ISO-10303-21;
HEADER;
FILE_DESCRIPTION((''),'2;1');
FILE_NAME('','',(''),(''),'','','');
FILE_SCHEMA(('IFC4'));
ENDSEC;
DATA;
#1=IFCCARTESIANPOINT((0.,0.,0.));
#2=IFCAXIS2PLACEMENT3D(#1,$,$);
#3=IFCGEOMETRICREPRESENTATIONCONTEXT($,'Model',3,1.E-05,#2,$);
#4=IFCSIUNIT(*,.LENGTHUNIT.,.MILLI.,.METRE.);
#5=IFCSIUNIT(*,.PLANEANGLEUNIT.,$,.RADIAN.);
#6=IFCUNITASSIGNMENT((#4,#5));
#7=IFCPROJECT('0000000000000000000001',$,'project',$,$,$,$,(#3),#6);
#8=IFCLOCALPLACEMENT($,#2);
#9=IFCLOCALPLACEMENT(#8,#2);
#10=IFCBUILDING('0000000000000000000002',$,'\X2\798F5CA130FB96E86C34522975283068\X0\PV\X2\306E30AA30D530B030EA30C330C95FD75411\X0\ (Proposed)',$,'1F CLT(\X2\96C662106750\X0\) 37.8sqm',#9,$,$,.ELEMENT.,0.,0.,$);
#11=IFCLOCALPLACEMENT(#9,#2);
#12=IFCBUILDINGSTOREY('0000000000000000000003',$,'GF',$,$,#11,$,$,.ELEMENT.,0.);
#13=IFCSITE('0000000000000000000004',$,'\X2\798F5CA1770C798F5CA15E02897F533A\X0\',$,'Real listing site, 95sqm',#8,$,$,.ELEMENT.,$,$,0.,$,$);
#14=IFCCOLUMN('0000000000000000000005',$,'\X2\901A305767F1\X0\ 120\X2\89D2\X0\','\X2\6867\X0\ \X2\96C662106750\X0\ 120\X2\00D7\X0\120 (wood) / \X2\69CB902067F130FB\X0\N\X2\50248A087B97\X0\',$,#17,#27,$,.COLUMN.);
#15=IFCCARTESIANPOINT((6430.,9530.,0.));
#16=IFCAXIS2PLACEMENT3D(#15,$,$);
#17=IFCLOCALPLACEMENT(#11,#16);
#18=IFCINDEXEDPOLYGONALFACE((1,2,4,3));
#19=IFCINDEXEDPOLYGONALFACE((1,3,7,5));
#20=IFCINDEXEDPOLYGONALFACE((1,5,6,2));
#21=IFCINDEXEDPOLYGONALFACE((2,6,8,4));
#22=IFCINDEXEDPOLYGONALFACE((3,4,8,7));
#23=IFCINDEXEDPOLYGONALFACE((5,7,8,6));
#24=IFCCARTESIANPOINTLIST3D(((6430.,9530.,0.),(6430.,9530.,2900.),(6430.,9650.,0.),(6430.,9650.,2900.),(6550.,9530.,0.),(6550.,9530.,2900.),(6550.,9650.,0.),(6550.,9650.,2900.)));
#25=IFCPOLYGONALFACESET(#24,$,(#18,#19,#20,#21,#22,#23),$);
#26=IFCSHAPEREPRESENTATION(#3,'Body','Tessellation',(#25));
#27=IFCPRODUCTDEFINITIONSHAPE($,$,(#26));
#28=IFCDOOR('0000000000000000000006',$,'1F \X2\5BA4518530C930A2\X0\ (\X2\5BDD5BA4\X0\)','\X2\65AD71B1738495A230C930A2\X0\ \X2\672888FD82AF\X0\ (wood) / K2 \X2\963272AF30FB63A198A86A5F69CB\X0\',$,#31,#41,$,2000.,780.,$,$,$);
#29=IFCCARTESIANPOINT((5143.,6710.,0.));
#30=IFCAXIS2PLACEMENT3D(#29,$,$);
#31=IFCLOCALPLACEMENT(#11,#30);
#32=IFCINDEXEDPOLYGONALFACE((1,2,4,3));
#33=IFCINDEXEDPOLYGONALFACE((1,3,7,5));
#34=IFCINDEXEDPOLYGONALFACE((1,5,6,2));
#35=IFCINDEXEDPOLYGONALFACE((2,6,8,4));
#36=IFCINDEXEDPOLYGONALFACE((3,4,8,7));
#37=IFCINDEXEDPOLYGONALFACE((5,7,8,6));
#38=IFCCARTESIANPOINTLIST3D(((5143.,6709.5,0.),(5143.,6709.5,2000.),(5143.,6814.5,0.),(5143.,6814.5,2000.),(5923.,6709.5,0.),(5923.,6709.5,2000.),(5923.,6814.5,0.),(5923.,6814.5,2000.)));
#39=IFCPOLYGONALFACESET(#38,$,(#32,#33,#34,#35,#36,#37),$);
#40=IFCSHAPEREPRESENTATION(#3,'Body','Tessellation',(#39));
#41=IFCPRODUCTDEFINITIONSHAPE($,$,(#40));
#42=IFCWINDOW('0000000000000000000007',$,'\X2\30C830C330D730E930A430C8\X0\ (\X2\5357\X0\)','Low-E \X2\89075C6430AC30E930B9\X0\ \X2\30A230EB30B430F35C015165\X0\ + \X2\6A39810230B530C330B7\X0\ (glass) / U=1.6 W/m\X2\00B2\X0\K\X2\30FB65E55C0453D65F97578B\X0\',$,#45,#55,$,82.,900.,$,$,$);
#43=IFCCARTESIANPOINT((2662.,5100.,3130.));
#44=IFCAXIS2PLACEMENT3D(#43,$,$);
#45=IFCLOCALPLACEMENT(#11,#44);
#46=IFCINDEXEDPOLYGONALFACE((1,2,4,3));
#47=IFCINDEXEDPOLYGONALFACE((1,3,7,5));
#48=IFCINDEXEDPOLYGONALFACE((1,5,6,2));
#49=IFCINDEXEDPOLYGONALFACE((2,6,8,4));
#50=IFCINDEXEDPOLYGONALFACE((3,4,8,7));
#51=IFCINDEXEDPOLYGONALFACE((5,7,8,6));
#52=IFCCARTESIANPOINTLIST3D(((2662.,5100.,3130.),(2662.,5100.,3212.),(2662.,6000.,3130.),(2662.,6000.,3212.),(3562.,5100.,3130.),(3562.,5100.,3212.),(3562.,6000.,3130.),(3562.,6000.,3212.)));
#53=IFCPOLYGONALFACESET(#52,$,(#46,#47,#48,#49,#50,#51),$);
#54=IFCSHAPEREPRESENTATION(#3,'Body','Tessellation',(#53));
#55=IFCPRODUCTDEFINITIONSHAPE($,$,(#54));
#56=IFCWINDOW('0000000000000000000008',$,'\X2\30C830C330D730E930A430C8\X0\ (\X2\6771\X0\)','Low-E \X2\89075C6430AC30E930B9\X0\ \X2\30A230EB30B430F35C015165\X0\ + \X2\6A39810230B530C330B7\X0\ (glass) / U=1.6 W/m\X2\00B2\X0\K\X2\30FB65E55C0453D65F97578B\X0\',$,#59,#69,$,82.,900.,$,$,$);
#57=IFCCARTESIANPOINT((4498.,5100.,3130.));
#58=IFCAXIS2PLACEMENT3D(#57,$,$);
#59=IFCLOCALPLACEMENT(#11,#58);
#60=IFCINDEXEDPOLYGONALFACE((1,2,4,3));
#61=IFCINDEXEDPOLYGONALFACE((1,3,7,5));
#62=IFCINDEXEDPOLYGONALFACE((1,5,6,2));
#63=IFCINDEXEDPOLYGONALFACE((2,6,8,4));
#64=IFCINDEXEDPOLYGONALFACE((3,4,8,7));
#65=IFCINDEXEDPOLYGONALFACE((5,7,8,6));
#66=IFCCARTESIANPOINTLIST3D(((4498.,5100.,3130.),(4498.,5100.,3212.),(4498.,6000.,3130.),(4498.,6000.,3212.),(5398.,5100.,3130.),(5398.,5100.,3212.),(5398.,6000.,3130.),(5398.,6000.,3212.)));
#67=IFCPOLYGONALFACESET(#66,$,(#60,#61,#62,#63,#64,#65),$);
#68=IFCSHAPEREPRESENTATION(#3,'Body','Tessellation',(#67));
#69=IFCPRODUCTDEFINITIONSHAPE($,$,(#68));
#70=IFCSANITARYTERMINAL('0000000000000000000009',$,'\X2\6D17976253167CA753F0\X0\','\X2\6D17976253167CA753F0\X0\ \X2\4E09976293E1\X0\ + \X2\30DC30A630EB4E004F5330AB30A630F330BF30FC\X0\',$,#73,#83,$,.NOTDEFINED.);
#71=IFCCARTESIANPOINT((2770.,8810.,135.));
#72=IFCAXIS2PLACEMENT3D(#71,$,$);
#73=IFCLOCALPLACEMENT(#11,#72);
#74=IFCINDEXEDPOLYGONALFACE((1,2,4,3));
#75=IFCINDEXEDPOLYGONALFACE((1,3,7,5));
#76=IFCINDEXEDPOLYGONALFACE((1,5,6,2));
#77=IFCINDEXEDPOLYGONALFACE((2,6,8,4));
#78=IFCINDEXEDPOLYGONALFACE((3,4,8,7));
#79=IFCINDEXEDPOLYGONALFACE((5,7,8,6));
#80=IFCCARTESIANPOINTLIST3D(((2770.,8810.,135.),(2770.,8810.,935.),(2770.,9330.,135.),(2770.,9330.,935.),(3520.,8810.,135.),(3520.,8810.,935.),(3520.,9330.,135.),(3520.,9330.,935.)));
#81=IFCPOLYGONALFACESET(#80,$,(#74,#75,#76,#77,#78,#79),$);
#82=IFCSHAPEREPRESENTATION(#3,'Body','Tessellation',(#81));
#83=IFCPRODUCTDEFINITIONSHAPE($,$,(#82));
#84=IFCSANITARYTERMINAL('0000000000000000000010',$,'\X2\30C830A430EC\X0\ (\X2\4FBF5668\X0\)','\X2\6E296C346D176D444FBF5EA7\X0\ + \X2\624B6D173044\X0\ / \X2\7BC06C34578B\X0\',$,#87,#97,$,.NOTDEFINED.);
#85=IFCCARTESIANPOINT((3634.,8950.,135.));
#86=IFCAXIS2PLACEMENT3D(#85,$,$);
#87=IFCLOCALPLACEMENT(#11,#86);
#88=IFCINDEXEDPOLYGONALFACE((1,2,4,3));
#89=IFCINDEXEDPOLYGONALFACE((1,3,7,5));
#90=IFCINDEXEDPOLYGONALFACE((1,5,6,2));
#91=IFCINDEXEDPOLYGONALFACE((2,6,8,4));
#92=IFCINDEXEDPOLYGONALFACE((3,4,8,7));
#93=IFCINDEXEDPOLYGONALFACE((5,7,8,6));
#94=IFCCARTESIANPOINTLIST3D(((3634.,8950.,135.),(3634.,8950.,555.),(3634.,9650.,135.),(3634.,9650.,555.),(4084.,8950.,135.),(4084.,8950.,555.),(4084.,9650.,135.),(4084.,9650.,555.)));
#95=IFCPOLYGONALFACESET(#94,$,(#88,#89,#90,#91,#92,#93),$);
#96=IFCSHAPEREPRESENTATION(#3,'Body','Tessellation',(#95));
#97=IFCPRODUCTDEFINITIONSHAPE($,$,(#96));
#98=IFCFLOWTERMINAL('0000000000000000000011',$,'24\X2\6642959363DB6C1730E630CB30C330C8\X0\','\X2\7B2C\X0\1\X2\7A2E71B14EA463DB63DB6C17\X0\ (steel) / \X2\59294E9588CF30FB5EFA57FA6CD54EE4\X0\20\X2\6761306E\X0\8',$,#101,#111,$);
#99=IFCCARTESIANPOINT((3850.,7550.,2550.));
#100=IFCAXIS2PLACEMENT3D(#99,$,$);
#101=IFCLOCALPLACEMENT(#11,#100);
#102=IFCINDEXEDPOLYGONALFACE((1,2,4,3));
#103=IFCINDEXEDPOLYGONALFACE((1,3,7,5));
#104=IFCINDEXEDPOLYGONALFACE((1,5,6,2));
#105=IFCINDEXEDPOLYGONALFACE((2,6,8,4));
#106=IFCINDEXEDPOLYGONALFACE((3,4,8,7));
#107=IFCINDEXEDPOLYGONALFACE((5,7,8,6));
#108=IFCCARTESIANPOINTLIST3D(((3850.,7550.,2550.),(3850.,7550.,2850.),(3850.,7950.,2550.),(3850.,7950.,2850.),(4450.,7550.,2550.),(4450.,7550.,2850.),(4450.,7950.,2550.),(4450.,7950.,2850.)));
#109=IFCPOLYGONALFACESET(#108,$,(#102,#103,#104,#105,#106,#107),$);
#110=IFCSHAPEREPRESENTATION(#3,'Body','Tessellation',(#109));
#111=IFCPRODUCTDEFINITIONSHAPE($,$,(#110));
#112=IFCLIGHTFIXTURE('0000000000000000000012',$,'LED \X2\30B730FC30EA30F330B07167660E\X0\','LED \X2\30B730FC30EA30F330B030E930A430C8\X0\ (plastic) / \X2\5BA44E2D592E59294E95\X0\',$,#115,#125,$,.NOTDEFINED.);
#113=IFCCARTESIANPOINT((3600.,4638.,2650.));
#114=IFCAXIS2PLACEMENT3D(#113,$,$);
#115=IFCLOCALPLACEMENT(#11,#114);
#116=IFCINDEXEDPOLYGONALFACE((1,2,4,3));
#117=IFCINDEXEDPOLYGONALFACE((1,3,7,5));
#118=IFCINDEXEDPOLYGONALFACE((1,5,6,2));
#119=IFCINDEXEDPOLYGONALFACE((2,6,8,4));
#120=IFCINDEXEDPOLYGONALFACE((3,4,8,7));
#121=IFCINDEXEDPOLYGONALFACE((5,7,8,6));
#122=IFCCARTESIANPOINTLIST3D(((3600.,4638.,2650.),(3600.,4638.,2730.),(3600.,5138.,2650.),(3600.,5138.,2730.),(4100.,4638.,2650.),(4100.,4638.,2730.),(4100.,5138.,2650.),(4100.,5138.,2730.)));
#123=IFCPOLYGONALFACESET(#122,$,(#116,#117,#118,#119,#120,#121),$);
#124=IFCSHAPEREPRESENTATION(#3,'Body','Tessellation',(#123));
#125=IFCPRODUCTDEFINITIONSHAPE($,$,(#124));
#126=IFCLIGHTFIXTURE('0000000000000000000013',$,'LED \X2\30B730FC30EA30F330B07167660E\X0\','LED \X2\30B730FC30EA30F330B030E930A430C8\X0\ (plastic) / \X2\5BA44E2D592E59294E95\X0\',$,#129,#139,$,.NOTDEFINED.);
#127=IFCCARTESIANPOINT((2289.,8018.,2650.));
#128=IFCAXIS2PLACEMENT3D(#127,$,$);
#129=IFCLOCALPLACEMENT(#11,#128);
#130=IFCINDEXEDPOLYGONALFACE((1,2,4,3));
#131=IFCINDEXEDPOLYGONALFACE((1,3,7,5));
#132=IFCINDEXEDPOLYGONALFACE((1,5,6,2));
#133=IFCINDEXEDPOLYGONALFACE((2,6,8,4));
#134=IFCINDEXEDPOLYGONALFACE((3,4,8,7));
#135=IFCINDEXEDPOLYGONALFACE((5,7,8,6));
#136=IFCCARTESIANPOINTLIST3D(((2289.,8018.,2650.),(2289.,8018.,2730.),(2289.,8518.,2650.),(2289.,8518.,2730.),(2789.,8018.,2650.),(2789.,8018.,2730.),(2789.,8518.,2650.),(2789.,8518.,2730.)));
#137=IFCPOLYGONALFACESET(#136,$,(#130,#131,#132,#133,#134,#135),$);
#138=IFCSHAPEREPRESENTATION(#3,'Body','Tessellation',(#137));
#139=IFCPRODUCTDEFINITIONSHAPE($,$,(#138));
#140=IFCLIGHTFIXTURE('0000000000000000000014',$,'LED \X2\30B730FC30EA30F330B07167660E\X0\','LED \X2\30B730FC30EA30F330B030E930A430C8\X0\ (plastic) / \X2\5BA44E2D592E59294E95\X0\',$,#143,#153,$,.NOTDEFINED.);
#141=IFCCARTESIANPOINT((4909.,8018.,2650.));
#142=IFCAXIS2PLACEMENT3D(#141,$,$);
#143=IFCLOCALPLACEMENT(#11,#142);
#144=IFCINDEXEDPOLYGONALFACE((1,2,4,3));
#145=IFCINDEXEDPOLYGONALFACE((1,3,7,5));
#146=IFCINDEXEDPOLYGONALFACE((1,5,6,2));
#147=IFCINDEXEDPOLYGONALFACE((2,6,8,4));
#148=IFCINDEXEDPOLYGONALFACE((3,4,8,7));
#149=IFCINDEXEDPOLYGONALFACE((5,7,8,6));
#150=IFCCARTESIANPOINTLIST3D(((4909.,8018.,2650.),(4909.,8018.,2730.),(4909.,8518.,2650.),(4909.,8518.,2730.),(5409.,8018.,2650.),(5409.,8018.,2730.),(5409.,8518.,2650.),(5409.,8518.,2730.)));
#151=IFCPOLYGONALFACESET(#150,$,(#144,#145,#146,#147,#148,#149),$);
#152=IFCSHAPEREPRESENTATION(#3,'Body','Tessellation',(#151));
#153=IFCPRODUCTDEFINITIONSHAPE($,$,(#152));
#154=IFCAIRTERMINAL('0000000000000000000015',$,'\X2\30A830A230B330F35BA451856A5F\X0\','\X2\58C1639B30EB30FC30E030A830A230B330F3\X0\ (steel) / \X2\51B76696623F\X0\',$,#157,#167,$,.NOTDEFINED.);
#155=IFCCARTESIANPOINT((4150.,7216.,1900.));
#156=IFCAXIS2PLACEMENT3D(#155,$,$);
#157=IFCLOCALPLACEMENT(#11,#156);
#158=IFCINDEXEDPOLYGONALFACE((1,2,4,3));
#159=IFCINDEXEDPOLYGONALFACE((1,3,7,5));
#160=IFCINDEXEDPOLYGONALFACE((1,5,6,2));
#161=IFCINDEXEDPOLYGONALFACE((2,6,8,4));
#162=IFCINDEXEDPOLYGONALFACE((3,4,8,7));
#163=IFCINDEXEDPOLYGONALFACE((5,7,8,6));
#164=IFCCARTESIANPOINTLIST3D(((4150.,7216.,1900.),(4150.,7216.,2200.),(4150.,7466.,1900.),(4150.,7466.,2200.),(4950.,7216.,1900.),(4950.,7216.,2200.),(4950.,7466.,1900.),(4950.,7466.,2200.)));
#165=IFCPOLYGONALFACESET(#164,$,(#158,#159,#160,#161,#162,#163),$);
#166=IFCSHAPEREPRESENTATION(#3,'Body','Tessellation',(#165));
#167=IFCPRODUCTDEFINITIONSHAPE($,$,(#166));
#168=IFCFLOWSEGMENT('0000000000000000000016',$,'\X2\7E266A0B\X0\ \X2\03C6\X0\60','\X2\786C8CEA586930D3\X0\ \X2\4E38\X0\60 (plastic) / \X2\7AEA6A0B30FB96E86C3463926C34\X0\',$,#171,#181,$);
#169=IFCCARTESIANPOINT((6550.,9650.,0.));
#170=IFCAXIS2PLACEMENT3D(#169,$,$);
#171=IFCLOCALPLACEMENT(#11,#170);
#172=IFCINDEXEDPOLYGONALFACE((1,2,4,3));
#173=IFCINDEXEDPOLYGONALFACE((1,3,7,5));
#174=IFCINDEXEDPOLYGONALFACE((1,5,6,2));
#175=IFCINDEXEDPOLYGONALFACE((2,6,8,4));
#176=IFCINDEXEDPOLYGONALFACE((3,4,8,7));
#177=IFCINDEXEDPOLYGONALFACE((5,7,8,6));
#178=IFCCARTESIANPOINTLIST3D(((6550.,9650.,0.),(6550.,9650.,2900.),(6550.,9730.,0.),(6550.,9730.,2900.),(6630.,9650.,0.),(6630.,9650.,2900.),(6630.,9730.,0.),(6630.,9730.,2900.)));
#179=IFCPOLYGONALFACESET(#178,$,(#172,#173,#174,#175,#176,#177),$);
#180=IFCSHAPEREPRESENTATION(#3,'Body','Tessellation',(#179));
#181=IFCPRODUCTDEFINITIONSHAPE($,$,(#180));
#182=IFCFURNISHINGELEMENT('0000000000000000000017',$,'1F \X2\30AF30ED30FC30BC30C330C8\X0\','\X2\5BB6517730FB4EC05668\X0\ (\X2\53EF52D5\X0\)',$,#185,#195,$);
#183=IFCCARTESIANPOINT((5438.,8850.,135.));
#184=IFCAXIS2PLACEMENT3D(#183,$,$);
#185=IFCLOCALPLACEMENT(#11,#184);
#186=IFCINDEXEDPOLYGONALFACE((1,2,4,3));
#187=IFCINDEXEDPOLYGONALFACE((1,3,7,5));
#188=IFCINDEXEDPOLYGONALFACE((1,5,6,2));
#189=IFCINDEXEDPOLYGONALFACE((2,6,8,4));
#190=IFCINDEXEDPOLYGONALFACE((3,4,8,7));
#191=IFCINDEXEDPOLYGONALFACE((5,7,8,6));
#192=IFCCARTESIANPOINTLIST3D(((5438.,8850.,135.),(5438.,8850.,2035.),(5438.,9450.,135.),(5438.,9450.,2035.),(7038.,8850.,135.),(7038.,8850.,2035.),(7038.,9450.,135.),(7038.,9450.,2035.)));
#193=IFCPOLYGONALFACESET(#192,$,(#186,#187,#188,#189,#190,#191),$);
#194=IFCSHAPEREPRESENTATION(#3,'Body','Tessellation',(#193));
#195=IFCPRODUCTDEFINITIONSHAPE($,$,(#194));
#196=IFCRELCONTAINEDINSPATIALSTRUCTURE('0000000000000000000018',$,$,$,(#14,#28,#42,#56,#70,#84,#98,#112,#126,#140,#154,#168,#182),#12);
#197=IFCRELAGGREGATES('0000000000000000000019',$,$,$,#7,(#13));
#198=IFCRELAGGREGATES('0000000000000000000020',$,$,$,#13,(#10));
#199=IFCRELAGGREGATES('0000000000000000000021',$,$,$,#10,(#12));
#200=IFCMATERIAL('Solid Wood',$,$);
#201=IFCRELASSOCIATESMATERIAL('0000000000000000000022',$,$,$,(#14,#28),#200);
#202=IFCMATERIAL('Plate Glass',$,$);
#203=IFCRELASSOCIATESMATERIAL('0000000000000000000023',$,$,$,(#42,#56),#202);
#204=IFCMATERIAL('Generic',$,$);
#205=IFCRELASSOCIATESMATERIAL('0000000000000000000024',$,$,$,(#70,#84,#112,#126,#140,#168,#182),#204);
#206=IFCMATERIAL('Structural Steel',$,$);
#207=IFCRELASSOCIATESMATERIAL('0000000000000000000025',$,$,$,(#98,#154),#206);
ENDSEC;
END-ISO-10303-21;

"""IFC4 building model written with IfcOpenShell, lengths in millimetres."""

from ifc_helpers import new_model, si_unit, frame, frame_2d, origin, place, context, project, spatial, rectangle, extrude, material, element, save


model = new_model("IFC4")

# Units and contexts
model_context = context("Model", 3, precision=1e-05, world=origin())
ifc_project = project(units=[si_unit("LENGTHUNIT", "METRE", prefix="MILLI"), si_unit("PLANEANGLEUNIT", "RADIAN")], contexts=[model_context])

# Site, building, storey
site_placement = place(None, origin())
site = spatial("IfcSite", under=ifc_project, at=site_placement, Name="福岡県福岡市西区", ObjectType="Real listing site, 95sqm", CompositionType="ELEMENT", RefElevation=0.0)
building_placement = place(site_placement, origin())
building = spatial("IfcBuilding", under=site, at=building_placement, Name="福岡・雨水利用とPVのオフグリッド志向 (Proposed)", ObjectType="1F CLT(集成材) 37.8sqm", CompositionType="ELEMENT", ElevationOfRefHeight=0.0, ElevationOfTerrain=0.0)
storey_placement = place(building_placement, origin())
storey = spatial("IfcBuildingStorey", under=building, at=storey_placement, Name="GF", CompositionType="ELEMENT", Elevation=0.0)

# Column
ifc_material_1 = material(Name="Solid Wood")
column_1_placement = place(storey_placement, frame((6430.0, 9530.0, 0.0)))
element("IfcColumn", 1, at=column_1_placement, inside=storey, material=ifc_material_1, Name="通し柱 120角", Description="桧 集成材 120×120 (wood) / 構造柱・N値計算", PredefinedType="COLUMN", context=model_context, shape_type="SweptSolid", body=[
    extrude(rectangle(XDim=120.0, YDim=120.0, at=frame_2d((60.0, 60.0))), frame((6430.0, 9530.0, 0.0)), (0.0, 0.0, 1.0), 2900.0),
])

# Door
door_placement = place(storey_placement, frame((5143.0, 6710.0, 0.0)))
element("IfcDoor", 2, at=door_placement, inside=storey, material=ifc_material_1, Name="1F 室内ドア (寝室)", Description="断熱玄関ドア 木製芯 (wood) / K2 防犯・採風機構", OverallHeight=2000.0, OverallWidth=780.0, context=model_context, shape_type="SweptSolid", body=[
    extrude(rectangle(XDim=780.0, YDim=105.0, at=frame_2d((390.0, 52.0))), frame((5143.0, 6710.0, 0.0)), (0.0, 0.0, 1.0), 2000.0),
])

# Windows
ifc_material_2 = material(Name="Plate Glass")
window_1_placement = place(storey_placement, frame((2662.0, 5100.0, 3130.0)))
element("IfcWindow", 3, at=window_1_placement, inside=storey, material=ifc_material_2, Name="トップライト (南)", Description="Low-E 複層ガラス アルゴン封入 + 樹脂サッシ (glass) / U=1.6 W/m²K・日射取得型", OverallHeight=82.0, OverallWidth=900.0, context=model_context, shape_type="SweptSolid", body=[
    extrude(rectangle(XDim=900.0, YDim=900.0, at=frame_2d((450.0, 450.0))), frame((2662.0, 5100.0, 3130.0)), (0.0, 0.0, 1.0), 82.0),
])
window_2_placement = place(storey_placement, frame((4498.0, 5100.0, 3130.0)))
element("IfcWindow", 4, at=window_2_placement, inside=storey, material=ifc_material_2, Name="トップライト (東)", Description="Low-E 複層ガラス アルゴン封入 + 樹脂サッシ (glass) / U=1.6 W/m²K・日射取得型", OverallHeight=82.0, OverallWidth=900.0, context=model_context, shape_type="SweptSolid", body=[
    extrude(rectangle(XDim=900.0, YDim=900.0, at=frame_2d((450.0, 450.0))), frame((4498.0, 5100.0, 3130.0)), (0.0, 0.0, 1.0), 82.0),
])

# Sanitary terminals
ifc_material_3 = material(Name="Generic")
sanitary_terminal_1_placement = place(storey_placement, frame((2770.0, 8810.0, 135.0)))
element("IfcSanitaryTerminal", 5, at=sanitary_terminal_1_placement, inside=storey, material=ifc_material_3, Name="洗面化粧台", Description="洗面化粧台 三面鏡 + ボウル一体カウンター", PredefinedType="NOTDEFINED", context=model_context, shape_type="SweptSolid", body=[
    extrude(rectangle(XDim=750.0, YDim=520.0, at=frame_2d((375.0, 260.0))), frame((2770.0, 8810.0, 135.0)), (0.0, 0.0, 1.0), 800.0),
])
sanitary_terminal_2_placement = place(storey_placement, frame((3634.0, 8950.0, 135.0)))
element("IfcSanitaryTerminal", 6, at=sanitary_terminal_2_placement, inside=storey, material=ifc_material_3, Name="トイレ (便器)", Description="温水洗浄便座 + 手洗い / 節水型", PredefinedType="NOTDEFINED", context=model_context, shape_type="SweptSolid", body=[
    extrude(rectangle(XDim=450.0, YDim=700.0, at=frame_2d((225.0, 350.0))), frame((3634.0, 8950.0, 135.0)), (0.0, 0.0, 1.0), 420.0),
])

# Flow terminal
ifc_material_4 = material(Name="Structural Steel")
flow_terminal_placement = place(storey_placement, frame((3850.0, 7550.0, 2550.0)))
element("IfcFlowTerminal", 7, at=flow_terminal_placement, inside=storey, material=ifc_material_4, Name="24時間換気ユニット", Description="第1種熱交換換気 (steel) / 天井裏・建基法令20条の8", context=model_context, shape_type="SweptSolid", body=[
    extrude(rectangle(XDim=600.0, YDim=400.0, at=frame_2d((300.0, 200.0))), frame((3850.0, 7550.0, 2550.0)), (0.0, 0.0, 1.0), 300.0),
])

# Light fixtures
light_fixture_1_placement = place(storey_placement, frame((3600.0, 4638.0, 2650.0)))
element("IfcLightFixture", 8, at=light_fixture_1_placement, inside=storey, material=ifc_material_3, Name="LED シーリング照明", Description="LED シーリングライト (plastic) / 室中央天井", PredefinedType="NOTDEFINED", context=model_context, shape_type="SweptSolid", body=[
    extrude(rectangle(XDim=500.0, YDim=500.0, at=frame_2d((250.0, 250.0))), frame((3600.0, 4638.0, 2650.0)), (0.0, 0.0, 1.0), 80.0),
])
light_fixture_2_placement = place(storey_placement, frame((2289.0, 8018.0, 2650.0)))
element("IfcLightFixture", 9, at=light_fixture_2_placement, inside=storey, material=ifc_material_3, Name="LED シーリング照明", Description="LED シーリングライト (plastic) / 室中央天井", PredefinedType="NOTDEFINED", context=model_context, shape_type="SweptSolid", body=[
    extrude(rectangle(XDim=500.0, YDim=500.0, at=frame_2d((250.0, 250.0))), frame((2289.0, 8018.0, 2650.0)), (0.0, 0.0, 1.0), 80.0),
])
light_fixture_3_placement = place(storey_placement, frame((4909.0, 8018.0, 2650.0)))
element("IfcLightFixture", 10, at=light_fixture_3_placement, inside=storey, material=ifc_material_3, Name="LED シーリング照明", Description="LED シーリングライト (plastic) / 室中央天井", PredefinedType="NOTDEFINED", context=model_context, shape_type="SweptSolid", body=[
    extrude(rectangle(XDim=500.0, YDim=500.0, at=frame_2d((250.0, 250.0))), frame((4909.0, 8018.0, 2650.0)), (0.0, 0.0, 1.0), 80.0),
])

# Air terminal
air_terminal_placement = place(storey_placement, frame((4150.0, 7216.0, 1900.0)))
element("IfcAirTerminal", 11, at=air_terminal_placement, inside=storey, material=ifc_material_4, Name="エアコン室内機", Description="壁掛ルームエアコン (steel) / 冷暖房", PredefinedType="NOTDEFINED", context=model_context, shape_type="SweptSolid", body=[
    extrude(rectangle(XDim=800.0, YDim=250.0, at=frame_2d((400.0, 125.0))), frame((4150.0, 7216.0, 1900.0)), (0.0, 0.0, 1.0), 300.0),
])

# Flow segment
flow_segment_placement = place(storey_placement, frame((6550.0, 9650.0, 0.0)))
element("IfcFlowSegment", 12, at=flow_segment_placement, inside=storey, material=ifc_material_3, Name="縦樋 φ60", Description="硬質塩ビ 丸60 (plastic) / 竪樋・雨水排水", context=model_context, shape_type="SweptSolid", body=[
    extrude(rectangle(XDim=80.0, YDim=80.0, at=frame_2d((40.0, 40.0))), frame((6550.0, 9650.0, 0.0)), (0.0, 0.0, 1.0), 2900.0),
])

# Furnishing element
furnishing_placement = place(storey_placement, frame((5438.0, 8850.0, 135.0)))
element("IfcFurnishingElement", 13, at=furnishing_placement, inside=storey, material=ifc_material_3, Name="1F クローゼット", Description="家具・什器 (可動)", context=model_context, shape_type="SweptSolid", body=[
    extrude(rectangle(XDim=1600.0, YDim=600.0, at=frame_2d((800.0, 300.0))), frame((5438.0, 8850.0, 135.0)), (0.0, 0.0, 1.0), 1900.0),
])

save(model, "model.ifc")
